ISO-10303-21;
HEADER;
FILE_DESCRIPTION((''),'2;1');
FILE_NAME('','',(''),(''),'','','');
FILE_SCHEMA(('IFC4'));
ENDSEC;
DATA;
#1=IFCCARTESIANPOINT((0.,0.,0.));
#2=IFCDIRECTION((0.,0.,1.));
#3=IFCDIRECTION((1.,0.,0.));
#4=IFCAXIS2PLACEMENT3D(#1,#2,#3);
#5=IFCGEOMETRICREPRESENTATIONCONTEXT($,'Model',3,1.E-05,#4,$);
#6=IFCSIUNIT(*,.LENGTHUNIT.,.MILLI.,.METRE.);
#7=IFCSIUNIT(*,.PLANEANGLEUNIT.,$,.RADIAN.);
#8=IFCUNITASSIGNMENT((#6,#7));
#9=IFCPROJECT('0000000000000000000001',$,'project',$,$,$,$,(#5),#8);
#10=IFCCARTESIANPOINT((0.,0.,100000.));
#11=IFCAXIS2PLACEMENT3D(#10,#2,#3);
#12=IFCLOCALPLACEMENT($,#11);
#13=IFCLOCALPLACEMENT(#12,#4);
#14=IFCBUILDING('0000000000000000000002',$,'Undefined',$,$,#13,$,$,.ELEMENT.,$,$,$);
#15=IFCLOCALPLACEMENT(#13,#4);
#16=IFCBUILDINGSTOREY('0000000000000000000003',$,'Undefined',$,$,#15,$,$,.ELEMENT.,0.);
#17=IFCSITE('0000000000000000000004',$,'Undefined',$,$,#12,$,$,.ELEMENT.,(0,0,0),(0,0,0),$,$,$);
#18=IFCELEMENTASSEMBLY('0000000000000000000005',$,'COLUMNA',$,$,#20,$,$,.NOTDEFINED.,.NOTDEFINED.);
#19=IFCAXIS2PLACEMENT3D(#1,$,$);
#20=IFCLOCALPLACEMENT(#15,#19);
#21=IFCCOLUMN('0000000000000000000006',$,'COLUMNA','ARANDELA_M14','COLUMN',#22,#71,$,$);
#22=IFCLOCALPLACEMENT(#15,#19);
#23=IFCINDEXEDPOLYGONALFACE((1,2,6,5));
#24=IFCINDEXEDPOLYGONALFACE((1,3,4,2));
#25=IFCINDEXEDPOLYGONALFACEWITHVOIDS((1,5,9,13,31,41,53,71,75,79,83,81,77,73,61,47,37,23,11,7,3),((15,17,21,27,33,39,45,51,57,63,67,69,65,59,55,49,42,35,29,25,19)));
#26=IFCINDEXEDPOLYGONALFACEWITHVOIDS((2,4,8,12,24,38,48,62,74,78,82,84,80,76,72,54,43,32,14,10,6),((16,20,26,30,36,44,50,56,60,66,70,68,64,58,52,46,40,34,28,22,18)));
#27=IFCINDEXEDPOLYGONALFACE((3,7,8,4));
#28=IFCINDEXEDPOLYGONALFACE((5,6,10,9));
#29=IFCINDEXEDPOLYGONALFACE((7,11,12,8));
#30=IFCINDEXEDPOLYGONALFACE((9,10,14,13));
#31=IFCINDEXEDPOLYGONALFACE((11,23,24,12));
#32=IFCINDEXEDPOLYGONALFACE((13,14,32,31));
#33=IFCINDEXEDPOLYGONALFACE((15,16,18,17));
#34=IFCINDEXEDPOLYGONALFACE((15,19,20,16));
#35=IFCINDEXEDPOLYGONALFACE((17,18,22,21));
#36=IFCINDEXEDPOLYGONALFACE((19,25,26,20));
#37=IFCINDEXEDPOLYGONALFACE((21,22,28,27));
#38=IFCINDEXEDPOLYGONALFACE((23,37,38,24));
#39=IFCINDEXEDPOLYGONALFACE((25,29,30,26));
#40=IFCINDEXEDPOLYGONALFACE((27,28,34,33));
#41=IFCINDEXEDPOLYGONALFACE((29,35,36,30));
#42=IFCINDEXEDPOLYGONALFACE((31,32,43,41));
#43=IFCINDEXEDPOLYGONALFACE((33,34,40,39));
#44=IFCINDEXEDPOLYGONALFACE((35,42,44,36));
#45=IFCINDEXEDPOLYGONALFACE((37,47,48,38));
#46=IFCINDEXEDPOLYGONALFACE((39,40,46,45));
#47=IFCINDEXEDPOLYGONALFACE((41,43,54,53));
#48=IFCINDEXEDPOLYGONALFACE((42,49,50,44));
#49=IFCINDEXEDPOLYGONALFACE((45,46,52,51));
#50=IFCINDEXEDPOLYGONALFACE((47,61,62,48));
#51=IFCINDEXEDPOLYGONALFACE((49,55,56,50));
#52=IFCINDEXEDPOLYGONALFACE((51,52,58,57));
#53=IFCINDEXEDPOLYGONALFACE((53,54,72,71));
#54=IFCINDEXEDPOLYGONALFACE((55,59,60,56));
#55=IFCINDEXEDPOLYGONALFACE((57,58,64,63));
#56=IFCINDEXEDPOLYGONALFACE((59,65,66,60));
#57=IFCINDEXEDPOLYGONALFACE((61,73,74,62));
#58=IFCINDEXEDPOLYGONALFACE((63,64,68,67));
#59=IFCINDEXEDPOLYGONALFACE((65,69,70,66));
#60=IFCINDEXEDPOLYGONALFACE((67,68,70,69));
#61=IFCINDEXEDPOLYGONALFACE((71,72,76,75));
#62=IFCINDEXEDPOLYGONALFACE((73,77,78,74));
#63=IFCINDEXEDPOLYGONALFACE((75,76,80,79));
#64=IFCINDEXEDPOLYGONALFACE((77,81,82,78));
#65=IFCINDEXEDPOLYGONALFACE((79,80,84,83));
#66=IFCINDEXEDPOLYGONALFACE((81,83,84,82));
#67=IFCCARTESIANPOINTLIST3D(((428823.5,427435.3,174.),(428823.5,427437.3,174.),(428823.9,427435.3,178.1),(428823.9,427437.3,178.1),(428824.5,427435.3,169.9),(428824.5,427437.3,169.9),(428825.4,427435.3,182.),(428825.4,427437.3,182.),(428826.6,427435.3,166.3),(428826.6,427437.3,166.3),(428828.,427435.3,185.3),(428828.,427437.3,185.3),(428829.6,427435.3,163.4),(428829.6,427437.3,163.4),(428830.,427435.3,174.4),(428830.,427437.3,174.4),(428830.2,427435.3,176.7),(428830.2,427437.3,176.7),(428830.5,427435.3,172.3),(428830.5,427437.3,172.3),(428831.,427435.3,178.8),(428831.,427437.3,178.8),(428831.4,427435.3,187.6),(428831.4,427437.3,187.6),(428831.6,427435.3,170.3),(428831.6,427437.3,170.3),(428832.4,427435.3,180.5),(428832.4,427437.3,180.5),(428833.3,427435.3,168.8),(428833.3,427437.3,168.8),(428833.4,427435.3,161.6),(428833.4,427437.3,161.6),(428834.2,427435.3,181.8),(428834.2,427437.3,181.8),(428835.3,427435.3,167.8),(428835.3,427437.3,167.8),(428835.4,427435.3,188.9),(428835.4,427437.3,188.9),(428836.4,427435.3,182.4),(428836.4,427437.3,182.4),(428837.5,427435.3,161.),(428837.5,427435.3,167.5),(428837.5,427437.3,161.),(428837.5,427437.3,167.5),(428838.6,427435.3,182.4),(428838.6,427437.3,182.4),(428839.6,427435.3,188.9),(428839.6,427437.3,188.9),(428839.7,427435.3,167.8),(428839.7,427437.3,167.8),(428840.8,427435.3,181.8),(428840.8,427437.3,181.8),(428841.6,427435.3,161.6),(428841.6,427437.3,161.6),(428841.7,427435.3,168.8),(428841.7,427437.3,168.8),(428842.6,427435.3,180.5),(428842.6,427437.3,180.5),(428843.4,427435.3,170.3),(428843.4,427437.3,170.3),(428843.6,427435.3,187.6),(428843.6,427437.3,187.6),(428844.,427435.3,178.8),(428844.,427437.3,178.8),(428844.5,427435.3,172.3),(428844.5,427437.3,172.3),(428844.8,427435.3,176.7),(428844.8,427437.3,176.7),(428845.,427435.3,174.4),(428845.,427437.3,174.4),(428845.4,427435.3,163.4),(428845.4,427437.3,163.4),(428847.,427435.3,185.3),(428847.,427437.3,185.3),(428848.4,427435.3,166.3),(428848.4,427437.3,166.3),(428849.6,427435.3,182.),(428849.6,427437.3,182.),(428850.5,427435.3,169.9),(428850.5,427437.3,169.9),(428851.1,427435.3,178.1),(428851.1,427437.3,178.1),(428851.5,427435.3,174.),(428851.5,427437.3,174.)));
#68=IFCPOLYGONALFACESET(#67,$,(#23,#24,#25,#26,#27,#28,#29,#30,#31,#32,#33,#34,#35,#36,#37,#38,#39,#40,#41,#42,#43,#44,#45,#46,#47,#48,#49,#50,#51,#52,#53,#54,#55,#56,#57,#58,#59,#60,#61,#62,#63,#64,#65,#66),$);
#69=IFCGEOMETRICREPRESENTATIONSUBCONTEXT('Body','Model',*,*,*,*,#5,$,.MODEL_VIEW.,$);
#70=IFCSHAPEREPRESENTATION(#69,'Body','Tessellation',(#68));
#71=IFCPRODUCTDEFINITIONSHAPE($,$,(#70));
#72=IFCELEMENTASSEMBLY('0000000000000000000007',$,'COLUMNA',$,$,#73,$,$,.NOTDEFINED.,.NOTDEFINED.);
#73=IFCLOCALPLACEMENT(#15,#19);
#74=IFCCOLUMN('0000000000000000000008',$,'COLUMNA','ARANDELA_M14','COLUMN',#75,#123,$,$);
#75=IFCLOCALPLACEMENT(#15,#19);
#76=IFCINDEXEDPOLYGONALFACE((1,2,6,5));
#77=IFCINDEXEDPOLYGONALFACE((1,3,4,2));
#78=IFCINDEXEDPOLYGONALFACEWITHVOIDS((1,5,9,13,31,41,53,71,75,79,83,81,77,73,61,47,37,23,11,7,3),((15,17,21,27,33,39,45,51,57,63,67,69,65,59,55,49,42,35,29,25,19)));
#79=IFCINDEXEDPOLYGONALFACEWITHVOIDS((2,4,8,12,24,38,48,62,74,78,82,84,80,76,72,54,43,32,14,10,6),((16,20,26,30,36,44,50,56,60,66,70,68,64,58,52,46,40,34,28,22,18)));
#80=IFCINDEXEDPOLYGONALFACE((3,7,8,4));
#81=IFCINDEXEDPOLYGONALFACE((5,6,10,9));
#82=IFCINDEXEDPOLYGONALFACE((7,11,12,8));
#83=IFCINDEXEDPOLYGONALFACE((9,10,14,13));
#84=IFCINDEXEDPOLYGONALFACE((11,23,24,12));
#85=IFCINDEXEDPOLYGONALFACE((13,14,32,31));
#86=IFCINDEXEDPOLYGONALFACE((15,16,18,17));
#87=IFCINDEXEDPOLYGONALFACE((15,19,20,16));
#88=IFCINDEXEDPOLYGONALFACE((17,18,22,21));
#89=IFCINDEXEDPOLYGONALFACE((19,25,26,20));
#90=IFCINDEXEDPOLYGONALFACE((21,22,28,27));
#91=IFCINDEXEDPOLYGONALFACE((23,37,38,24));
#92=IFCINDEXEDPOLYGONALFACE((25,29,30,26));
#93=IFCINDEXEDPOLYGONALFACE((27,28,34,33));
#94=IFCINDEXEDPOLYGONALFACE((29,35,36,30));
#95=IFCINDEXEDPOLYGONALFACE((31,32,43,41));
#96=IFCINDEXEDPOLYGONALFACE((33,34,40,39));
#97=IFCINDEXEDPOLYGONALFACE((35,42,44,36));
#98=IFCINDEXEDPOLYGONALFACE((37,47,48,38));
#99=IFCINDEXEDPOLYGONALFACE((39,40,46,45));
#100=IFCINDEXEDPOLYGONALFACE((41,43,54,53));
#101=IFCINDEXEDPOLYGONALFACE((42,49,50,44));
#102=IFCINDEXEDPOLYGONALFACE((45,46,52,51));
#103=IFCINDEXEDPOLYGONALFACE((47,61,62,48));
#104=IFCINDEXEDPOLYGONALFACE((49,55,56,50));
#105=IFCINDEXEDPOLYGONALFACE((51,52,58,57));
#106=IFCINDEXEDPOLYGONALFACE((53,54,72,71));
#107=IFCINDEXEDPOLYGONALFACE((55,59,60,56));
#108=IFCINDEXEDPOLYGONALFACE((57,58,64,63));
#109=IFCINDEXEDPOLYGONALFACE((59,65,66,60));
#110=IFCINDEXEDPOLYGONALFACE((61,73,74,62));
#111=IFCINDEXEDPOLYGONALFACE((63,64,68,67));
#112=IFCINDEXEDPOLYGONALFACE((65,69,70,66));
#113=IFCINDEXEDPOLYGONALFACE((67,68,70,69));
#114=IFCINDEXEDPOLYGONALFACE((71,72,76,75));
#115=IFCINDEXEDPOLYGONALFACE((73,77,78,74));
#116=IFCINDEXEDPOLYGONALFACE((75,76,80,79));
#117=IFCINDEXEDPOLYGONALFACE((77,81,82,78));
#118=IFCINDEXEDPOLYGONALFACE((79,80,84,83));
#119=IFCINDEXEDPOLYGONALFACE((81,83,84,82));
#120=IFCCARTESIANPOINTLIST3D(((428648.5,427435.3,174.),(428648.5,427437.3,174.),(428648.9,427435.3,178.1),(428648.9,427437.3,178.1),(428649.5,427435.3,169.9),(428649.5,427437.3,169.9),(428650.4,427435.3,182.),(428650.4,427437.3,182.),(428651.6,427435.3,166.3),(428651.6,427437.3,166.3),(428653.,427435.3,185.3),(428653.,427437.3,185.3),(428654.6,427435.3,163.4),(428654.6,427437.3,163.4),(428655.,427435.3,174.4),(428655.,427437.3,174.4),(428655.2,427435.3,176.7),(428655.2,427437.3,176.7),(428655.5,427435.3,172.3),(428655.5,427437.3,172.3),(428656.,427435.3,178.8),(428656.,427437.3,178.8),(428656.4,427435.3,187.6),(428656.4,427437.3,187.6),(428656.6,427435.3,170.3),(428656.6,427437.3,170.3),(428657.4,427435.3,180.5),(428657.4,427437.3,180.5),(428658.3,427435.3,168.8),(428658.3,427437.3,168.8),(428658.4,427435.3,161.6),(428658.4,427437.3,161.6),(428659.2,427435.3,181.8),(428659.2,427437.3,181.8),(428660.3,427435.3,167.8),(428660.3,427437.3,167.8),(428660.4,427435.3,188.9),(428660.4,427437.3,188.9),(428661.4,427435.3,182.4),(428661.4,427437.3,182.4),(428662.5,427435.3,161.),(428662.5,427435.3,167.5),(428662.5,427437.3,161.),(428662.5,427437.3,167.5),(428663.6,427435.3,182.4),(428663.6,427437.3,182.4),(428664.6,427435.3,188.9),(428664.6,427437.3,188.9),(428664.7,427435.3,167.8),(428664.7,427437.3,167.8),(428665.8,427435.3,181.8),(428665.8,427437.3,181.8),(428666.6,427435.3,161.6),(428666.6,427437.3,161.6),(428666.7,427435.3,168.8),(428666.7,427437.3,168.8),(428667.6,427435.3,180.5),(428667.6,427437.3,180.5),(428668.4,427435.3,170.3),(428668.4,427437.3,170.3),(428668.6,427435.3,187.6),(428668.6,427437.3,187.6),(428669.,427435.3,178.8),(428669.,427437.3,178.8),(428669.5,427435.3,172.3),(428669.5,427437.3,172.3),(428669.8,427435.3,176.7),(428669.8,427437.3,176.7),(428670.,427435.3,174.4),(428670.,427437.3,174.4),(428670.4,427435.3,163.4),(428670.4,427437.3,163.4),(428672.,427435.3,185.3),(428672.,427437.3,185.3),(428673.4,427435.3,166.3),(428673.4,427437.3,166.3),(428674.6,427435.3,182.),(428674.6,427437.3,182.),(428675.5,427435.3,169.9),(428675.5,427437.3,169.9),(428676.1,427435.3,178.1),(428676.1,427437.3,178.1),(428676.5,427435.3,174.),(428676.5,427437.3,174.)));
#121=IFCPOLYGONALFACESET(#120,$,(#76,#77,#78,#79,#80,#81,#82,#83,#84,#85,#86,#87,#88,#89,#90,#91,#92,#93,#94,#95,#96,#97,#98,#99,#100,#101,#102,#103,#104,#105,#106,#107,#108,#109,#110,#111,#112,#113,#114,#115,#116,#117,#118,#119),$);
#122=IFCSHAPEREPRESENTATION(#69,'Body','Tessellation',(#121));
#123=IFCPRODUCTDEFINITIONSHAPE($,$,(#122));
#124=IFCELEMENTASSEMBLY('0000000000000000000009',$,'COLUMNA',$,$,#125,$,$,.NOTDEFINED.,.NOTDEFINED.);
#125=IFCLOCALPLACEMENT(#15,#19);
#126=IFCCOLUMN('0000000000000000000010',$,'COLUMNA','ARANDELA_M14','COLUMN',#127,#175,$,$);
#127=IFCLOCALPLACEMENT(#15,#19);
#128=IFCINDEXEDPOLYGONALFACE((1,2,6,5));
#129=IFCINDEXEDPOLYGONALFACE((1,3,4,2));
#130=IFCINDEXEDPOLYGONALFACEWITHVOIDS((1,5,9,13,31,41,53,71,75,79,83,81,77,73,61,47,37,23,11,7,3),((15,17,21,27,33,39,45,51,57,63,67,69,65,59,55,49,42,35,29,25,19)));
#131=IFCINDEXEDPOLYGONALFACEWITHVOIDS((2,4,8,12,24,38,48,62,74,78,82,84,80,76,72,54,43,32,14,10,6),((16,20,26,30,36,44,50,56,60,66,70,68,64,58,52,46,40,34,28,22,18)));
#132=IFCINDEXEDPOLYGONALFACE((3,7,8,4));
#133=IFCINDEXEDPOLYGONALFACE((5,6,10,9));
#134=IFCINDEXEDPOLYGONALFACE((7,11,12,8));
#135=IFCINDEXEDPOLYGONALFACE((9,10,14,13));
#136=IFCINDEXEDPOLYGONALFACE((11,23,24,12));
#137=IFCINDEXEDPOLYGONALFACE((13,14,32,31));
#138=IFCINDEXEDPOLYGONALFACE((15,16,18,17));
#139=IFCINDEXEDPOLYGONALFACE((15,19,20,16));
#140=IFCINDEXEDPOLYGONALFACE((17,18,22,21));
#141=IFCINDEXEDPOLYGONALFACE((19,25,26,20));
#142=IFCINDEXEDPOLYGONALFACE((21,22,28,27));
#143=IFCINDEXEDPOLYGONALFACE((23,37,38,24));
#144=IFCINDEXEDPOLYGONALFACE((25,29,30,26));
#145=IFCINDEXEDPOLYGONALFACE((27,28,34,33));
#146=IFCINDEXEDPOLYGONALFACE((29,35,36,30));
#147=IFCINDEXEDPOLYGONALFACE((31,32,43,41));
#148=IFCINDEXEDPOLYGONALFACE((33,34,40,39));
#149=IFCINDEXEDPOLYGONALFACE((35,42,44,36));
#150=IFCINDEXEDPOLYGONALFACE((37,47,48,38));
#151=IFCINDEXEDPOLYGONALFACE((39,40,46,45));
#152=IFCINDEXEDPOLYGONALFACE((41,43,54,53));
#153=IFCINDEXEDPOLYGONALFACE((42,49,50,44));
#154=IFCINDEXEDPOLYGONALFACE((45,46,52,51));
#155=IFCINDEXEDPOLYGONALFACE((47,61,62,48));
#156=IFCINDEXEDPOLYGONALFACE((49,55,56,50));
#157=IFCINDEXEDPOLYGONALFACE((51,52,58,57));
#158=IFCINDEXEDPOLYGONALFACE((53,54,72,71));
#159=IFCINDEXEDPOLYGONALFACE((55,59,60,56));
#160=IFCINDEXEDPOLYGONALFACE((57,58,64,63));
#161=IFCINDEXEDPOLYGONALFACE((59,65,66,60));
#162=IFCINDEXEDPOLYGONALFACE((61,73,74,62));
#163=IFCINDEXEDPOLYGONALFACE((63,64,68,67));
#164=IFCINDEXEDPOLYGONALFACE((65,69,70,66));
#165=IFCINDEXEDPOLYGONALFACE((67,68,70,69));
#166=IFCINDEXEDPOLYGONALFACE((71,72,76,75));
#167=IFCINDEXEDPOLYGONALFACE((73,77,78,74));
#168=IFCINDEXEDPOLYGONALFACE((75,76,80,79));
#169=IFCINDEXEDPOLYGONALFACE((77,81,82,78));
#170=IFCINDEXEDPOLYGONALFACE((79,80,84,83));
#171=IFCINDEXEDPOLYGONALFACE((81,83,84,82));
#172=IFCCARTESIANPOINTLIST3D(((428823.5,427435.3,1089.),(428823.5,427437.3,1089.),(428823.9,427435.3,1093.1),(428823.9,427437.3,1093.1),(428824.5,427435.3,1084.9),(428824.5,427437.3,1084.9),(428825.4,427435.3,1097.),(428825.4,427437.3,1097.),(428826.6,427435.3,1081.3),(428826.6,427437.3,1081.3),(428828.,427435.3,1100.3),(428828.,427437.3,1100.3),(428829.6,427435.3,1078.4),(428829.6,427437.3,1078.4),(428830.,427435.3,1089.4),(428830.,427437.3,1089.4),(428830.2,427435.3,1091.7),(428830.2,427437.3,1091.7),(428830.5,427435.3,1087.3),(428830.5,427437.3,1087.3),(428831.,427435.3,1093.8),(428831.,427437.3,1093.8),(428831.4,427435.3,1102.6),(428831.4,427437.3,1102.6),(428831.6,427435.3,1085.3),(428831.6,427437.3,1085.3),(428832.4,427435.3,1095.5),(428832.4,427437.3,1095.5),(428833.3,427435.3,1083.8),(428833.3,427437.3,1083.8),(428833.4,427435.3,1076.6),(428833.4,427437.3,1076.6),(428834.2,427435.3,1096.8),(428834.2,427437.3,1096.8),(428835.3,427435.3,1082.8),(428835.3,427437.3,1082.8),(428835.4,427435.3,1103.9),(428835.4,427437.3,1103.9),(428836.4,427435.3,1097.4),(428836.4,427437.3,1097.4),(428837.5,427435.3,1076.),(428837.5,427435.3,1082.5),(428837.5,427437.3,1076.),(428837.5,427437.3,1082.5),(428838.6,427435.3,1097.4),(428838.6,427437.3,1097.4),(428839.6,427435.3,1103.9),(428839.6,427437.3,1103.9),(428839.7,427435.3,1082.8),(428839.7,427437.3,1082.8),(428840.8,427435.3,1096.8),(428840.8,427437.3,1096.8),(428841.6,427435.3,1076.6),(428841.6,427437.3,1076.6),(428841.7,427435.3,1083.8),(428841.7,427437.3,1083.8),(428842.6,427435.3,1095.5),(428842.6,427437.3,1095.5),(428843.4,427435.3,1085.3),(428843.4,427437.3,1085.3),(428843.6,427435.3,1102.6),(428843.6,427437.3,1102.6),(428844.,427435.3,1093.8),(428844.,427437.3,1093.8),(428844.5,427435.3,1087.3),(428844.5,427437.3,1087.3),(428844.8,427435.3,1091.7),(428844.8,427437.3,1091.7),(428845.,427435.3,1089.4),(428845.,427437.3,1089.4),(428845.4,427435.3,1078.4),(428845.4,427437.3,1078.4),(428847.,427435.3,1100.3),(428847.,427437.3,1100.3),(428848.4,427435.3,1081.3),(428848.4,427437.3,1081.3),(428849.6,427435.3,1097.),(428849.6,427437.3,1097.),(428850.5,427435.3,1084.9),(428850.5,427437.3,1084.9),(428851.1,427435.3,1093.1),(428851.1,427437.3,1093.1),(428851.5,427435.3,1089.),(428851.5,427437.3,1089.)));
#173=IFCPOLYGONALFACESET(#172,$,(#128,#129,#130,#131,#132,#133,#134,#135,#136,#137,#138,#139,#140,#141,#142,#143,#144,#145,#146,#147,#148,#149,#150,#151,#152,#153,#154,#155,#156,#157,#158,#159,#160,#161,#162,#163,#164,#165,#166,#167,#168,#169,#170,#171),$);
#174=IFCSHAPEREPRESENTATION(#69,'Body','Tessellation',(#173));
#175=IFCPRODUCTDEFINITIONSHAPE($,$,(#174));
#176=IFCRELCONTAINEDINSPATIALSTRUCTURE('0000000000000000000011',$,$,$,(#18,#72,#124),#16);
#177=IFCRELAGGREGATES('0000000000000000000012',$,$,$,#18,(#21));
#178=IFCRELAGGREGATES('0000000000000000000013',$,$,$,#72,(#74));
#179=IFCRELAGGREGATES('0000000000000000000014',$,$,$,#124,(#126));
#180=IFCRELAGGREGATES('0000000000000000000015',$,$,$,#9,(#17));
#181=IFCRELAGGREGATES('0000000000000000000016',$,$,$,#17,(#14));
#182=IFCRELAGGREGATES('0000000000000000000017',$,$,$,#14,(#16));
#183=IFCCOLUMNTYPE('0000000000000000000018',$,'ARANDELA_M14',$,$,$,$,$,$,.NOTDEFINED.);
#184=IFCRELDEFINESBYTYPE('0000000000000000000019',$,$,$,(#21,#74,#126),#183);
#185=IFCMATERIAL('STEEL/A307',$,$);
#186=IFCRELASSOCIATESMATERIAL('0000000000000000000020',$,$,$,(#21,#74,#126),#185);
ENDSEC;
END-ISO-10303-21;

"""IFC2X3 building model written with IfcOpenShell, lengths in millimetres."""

from ifc_helpers import new_model, si_unit, frame, origin_with_axes, origin_2d_with_axis, place, context, subcontext, project, spatial, hollow_circle, extrude, material, type_object, element, aggregate, save


model = new_model("IFC2X3")

# Units and contexts
model_context = context("Model", 3, precision=1e-05, world=origin_with_axes())
body_context = subcontext(model_context, "Body", "Model", "MODEL_VIEW")
ifc_project = project(units=[si_unit("LENGTHUNIT", "METRE", prefix="MILLI"), si_unit("PLANEANGLEUNIT", "RADIAN")], contexts=[model_context])

# Site, building, storey
site_placement = place(None, frame((0.0, 0.0, 100000.0), z_axis=(0.0, 0.0, 1.0), x_axis=(1.0, 0.0, 0.0)))
site = spatial("IfcSite", under=ifc_project, at=site_placement, Name="Undefined", CompositionType="ELEMENT", RefLatitude=(0, 0, 0), RefLongitude=(0, 0, 0))
building_placement = place(site_placement, origin_with_axes())
building = spatial("IfcBuilding", under=site, at=building_placement, Name="Undefined", CompositionType="ELEMENT")
storey_placement = place(building_placement, origin_with_axes())
storey = spatial("IfcBuildingStorey", under=building, at=storey_placement, Name="Undefined", CompositionType="ELEMENT", Elevation=0.0)

# Element assemblies, columns
assembly_1_placement = place(storey_placement, origin_with_axes())
assembly_1 = element("IfcElementAssembly", 1, at=assembly_1_placement, inside=storey, Name="COLUMNA", AssemblyPlace="NOTDEFINED", PredefinedType="NOTDEFINED")
ifc_material_1 = material(Name="STEEL/A307")
column_type_1 = type_object("IfcColumnType", Name="ARANDELA_M14", PredefinedType="NOTDEFINED")
column_1_placement = place(assembly_1_placement, frame((428837.5, 427437.3, 175.0), z_axis=(0.0, -1.0, 0.000285), x_axis=(-1.0, 0.0, 0.0)))
column_1 = element("IfcColumn", 2, at=column_1_placement, type_object=column_type_1, material=ifc_material_1, Name="COLUMNA", Description="ARANDELA_M14", ObjectType="COLUMN", context=body_context, shape_type="SweptSolid", body=[
    extrude(hollow_circle(Radius=14.0, WallThickness=6.5, at=origin_2d_with_axis()), frame((0.0, 0.0, 2.0), z_axis=(0.0, 0.0, -1.0), x_axis=(0.0, 1.0, 0.0)), (0.0, 0.0, 1.0), 2.0),
])
aggregate(assembly_1, [column_1])
assembly_2_placement = place(storey_placement, origin_with_axes())
assembly_2 = element("IfcElementAssembly", 3, at=assembly_2_placement, inside=storey, Name="COLUMNA", AssemblyPlace="NOTDEFINED", PredefinedType="NOTDEFINED")
column_2_placement = place(assembly_2_placement, frame((428662.5, 427437.3, 175.0), z_axis=(0.0, -1.0, 0.000285), x_axis=(-1.0, 0.0, 0.0)))
column_2 = element("IfcColumn", 4, at=column_2_placement, type_object=column_type_1, material=ifc_material_1, Name="COLUMNA", Description="ARANDELA_M14", ObjectType="COLUMN", context=body_context, shape_type="SweptSolid", body=[
    extrude(hollow_circle(Radius=14.0, WallThickness=6.5, at=origin_2d_with_axis()), frame((0.0, 0.0, 2.0), z_axis=(0.0, 0.0, -1.0), x_axis=(0.0, 1.0, 0.0)), (0.0, 0.0, 1.0), 2.0),
])
aggregate(assembly_2, [column_2])
assembly_3_placement = place(storey_placement, origin_with_axes())
assembly_3 = element("IfcElementAssembly", 5, at=assembly_3_placement, inside=storey, Name="COLUMNA", AssemblyPlace="NOTDEFINED", PredefinedType="NOTDEFINED")
column_3_placement = place(assembly_3_placement, frame((428837.5, 427437.3, 1090.0), z_axis=(0.0, -1.0, 0.000285), x_axis=(-1.0, 0.0, 0.0)))
column_3 = element("IfcColumn", 6, at=column_3_placement, type_object=column_type_1, material=ifc_material_1, Name="COLUMNA", Description="ARANDELA_M14", ObjectType="COLUMN", context=body_context, shape_type="SweptSolid", body=[
    extrude(hollow_circle(Radius=14.0, WallThickness=6.5, at=origin_2d_with_axis()), frame((0.0, 0.0, 2.0), z_axis=(0.0, 0.0, -1.0), x_axis=(0.0, 1.0, 0.0)), (0.0, 0.0, 1.0), 2.0),
])
aggregate(assembly_3, [column_3])

save(model, "model.ifc")
